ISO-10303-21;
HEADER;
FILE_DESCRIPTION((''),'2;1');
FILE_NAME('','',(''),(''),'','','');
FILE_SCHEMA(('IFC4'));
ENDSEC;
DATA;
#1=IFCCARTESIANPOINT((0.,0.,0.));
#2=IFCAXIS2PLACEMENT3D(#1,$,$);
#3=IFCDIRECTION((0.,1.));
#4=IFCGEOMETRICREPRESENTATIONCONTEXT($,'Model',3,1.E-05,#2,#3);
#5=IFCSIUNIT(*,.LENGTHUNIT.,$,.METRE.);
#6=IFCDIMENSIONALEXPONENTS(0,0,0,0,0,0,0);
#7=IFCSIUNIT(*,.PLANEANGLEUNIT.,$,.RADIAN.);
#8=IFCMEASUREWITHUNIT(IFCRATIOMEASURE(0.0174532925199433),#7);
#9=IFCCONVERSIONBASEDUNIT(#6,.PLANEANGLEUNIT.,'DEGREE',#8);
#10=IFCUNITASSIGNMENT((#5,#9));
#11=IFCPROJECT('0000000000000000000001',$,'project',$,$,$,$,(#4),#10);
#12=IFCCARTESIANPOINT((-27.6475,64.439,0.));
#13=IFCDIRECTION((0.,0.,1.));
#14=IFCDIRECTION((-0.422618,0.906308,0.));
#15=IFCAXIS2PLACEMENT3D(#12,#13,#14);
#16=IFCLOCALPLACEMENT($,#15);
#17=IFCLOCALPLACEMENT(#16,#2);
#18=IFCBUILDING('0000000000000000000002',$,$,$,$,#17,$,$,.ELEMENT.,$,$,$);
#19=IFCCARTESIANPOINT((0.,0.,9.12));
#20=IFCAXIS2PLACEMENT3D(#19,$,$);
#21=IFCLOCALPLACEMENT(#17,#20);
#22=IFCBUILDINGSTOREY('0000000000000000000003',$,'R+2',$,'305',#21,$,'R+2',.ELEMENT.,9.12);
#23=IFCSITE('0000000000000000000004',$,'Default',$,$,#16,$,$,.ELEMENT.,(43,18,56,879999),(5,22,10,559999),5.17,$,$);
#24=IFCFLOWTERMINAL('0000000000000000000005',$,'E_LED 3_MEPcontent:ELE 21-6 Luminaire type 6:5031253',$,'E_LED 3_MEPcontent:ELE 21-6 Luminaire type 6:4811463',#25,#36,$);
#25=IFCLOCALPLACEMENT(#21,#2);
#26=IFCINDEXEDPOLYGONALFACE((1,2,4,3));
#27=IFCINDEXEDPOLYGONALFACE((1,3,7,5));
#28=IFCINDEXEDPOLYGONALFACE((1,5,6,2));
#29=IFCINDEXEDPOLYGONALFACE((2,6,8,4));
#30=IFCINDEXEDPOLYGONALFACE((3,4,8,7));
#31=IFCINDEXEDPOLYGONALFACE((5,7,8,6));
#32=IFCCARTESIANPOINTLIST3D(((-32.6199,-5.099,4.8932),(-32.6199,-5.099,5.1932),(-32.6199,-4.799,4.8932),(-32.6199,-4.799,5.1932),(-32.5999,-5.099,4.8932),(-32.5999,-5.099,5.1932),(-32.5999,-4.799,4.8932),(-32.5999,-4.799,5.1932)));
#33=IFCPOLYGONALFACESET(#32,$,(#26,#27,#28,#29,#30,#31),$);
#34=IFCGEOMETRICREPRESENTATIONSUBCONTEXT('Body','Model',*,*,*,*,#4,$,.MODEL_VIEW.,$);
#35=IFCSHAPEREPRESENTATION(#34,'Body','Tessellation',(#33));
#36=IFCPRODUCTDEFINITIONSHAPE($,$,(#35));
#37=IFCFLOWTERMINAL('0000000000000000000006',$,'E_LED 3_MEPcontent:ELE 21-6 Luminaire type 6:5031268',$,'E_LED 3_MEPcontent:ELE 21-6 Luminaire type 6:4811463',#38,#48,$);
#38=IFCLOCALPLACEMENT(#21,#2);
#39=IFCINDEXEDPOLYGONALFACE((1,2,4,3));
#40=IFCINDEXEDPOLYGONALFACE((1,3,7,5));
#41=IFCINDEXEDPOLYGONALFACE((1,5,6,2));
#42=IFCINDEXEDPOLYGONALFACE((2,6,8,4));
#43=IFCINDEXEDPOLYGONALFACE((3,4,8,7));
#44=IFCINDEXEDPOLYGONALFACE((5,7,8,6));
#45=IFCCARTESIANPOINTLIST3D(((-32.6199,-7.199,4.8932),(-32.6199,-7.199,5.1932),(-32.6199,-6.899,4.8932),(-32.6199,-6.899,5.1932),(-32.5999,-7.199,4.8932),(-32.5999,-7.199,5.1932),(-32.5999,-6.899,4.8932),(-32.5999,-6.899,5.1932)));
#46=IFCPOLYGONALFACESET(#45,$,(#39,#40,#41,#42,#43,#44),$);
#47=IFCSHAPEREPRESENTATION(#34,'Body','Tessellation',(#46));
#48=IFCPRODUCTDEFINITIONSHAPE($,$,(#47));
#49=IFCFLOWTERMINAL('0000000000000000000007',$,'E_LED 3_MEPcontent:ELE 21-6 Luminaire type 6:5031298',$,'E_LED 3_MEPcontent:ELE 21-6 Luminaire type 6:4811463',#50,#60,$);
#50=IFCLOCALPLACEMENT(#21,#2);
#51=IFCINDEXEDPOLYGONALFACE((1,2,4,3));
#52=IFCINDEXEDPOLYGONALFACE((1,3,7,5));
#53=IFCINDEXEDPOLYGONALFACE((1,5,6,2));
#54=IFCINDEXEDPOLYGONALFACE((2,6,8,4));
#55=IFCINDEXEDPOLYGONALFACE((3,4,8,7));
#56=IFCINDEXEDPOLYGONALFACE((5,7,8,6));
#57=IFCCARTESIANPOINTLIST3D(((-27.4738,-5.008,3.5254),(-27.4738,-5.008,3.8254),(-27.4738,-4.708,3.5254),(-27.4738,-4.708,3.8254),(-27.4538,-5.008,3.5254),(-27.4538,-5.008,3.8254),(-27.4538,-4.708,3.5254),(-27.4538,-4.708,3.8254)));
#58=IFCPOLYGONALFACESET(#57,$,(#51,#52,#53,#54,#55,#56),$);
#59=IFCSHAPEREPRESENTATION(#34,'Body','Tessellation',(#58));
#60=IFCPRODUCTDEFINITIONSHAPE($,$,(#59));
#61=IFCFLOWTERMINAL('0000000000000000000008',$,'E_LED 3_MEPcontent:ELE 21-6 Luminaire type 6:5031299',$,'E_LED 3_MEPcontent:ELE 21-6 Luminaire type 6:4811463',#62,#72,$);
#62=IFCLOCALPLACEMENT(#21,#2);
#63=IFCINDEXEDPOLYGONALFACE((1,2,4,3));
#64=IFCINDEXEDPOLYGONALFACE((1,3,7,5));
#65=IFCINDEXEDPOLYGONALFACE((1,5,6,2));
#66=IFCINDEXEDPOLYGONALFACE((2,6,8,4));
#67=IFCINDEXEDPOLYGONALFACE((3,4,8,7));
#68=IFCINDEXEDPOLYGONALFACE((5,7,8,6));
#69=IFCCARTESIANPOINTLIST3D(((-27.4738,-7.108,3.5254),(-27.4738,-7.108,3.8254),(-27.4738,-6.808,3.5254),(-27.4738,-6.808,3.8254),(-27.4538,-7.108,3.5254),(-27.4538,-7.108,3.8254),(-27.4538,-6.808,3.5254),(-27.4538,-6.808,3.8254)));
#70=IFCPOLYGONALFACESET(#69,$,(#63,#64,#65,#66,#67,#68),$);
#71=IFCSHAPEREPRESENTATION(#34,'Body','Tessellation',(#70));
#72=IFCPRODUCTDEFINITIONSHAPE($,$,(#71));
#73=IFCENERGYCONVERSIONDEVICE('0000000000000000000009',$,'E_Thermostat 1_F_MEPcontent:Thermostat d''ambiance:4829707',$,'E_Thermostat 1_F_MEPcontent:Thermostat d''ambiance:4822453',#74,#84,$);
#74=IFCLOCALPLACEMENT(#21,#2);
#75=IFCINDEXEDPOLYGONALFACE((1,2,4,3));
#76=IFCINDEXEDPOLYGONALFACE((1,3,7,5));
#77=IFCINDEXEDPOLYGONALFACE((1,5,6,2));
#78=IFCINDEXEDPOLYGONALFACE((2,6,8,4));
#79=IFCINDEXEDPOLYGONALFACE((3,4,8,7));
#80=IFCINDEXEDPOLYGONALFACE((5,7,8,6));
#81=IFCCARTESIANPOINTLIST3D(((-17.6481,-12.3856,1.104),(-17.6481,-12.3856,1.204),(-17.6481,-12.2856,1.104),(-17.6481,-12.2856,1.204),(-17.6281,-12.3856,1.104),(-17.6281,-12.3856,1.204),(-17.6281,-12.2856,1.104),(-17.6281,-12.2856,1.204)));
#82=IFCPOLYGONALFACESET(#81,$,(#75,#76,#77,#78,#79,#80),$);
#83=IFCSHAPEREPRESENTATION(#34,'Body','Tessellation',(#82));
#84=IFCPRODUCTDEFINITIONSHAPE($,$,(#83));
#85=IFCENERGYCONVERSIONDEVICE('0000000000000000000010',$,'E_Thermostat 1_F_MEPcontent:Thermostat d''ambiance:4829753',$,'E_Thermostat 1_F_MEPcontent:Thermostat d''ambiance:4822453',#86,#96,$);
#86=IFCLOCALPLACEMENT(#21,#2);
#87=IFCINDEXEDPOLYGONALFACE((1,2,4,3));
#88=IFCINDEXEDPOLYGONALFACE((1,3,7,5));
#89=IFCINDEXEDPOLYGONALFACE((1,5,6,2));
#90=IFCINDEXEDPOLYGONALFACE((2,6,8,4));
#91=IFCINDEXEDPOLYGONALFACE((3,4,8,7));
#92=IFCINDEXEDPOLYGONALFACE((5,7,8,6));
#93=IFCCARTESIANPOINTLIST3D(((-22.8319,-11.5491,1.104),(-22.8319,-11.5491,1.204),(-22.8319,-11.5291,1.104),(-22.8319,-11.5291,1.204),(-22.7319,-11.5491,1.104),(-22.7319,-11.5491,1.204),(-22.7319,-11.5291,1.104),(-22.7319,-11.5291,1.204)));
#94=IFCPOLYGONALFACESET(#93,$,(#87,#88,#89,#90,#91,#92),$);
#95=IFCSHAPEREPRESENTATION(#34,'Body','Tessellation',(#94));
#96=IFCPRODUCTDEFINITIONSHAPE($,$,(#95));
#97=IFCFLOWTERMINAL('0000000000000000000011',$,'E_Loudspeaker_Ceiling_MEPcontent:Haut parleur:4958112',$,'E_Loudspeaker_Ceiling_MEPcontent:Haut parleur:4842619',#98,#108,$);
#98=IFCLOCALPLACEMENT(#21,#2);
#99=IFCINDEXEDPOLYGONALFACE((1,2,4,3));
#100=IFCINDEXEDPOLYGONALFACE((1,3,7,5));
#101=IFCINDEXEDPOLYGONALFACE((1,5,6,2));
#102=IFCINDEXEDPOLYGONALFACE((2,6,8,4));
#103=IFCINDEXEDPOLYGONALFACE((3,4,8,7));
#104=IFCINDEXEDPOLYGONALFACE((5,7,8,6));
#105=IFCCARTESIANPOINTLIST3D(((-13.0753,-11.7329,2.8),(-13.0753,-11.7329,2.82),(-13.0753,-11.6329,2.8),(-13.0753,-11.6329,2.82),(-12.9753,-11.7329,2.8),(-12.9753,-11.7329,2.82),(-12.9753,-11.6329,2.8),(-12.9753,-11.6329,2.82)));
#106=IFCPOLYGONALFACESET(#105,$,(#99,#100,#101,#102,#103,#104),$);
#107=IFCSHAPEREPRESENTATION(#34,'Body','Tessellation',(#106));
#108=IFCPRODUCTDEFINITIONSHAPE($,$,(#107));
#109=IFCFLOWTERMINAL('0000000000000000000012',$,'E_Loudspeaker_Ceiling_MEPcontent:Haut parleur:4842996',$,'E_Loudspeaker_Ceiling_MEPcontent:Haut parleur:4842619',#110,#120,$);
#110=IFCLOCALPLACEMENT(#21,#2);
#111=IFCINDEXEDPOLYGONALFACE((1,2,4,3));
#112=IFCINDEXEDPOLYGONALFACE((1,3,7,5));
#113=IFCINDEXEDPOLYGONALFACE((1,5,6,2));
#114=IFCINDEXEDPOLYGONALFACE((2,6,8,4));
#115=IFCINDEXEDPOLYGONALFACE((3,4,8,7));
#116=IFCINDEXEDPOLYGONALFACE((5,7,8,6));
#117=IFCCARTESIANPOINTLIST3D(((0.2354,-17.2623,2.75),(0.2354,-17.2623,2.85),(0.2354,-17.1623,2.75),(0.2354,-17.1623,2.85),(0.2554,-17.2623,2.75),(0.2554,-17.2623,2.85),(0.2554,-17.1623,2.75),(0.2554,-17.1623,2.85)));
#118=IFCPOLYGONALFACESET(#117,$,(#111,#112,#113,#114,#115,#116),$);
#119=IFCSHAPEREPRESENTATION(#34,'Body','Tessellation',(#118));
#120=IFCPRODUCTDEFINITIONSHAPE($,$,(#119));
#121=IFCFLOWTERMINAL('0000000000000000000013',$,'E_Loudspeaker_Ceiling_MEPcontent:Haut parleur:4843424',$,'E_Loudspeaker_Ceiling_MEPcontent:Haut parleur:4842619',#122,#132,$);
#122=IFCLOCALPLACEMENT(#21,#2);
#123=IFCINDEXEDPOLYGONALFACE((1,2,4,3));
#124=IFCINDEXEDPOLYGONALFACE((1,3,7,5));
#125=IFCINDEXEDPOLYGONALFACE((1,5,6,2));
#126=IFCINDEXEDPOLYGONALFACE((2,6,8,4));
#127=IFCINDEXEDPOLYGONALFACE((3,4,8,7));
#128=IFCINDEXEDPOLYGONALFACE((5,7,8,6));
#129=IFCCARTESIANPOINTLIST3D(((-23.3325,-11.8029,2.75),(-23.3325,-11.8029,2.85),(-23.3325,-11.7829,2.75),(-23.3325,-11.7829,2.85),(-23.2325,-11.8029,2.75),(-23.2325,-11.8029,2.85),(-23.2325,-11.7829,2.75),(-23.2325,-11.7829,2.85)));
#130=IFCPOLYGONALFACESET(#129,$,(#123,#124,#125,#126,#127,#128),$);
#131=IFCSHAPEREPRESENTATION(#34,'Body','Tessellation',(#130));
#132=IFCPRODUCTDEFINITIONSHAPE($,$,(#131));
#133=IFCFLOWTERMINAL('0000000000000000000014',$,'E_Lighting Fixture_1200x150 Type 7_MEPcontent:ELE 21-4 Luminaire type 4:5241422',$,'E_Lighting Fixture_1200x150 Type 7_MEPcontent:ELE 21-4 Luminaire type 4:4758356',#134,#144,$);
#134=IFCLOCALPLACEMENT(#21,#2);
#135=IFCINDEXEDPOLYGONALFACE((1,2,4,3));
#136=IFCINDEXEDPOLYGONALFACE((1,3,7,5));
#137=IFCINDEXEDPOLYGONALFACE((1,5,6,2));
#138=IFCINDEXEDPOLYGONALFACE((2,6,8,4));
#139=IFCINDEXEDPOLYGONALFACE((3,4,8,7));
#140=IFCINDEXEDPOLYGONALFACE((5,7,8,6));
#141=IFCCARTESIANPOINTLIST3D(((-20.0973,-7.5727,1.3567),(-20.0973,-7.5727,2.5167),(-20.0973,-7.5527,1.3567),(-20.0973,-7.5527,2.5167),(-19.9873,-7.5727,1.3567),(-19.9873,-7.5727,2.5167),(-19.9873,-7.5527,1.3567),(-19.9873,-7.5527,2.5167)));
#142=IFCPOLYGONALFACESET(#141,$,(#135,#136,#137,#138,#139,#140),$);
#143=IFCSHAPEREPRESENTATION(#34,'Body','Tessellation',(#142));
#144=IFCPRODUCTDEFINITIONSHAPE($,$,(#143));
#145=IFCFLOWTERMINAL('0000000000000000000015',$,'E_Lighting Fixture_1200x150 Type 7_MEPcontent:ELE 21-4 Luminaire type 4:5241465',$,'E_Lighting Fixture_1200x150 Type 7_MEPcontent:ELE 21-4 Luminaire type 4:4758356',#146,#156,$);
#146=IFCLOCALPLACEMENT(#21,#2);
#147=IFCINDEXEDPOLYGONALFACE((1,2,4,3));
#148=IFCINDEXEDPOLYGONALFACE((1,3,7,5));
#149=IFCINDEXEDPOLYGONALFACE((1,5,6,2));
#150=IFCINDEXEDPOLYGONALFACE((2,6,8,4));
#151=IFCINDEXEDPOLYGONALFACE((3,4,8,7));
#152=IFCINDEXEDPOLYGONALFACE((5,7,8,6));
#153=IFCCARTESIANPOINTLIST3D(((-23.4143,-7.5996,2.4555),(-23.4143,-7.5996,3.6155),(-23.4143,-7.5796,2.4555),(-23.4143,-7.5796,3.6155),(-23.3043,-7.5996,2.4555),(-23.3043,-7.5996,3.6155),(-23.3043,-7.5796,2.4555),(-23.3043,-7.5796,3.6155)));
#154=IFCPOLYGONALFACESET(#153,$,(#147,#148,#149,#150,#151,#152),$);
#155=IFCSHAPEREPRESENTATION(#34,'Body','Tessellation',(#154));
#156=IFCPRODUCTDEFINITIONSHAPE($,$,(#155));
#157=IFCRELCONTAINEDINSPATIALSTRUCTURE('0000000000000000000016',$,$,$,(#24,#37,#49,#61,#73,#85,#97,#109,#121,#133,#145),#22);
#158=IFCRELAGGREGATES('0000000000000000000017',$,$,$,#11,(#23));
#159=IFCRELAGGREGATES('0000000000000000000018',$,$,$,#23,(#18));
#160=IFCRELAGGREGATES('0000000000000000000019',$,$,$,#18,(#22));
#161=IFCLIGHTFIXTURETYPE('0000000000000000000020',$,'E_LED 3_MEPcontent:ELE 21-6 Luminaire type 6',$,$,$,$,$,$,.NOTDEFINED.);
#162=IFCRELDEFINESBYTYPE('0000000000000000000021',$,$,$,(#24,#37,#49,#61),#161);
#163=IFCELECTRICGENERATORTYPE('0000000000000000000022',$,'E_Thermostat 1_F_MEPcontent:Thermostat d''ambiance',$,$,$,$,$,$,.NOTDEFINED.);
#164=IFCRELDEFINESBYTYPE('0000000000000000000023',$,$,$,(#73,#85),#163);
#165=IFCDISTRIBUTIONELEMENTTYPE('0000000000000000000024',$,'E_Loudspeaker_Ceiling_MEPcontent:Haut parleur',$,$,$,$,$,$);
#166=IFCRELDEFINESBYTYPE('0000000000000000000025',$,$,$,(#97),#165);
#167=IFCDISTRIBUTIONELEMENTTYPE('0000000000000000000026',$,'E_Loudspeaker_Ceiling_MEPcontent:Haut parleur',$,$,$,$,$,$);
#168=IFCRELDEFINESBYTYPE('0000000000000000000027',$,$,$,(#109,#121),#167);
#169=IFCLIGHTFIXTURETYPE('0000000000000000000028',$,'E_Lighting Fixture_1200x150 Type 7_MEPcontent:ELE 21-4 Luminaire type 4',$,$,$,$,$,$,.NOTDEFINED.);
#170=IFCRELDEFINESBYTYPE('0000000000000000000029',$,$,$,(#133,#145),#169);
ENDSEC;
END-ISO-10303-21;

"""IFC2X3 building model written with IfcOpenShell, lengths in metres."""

from ifc_helpers import new_model, entity, si_unit, converted_unit, direction, frame, frame_2d, origin, origin_2d_with_axis, place, context, subcontext, project, spatial, rectangle, extrude, source, transform, mapped, type_object, type_shapes, element, save


model = new_model("IFC2X3")

# Units and contexts
model_context = context("Model", 3, precision=1e-05, world=origin(), true_north=direction((0.0, 1.0)))
body_context = subcontext(model_context, "Body", "Model", "MODEL_VIEW")
ifc_project = project(units=[si_unit("LENGTHUNIT", "METRE"), converted_unit("PLANEANGLEUNIT", "DEGREE", entity("IfcRatioMeasure", 0.0174532925199433), si_unit("PLANEANGLEUNIT", "RADIAN"), dimensions=[0, 0, 0, 0, 0, 0, 0])], contexts=[model_context])

# Site, building, storey
site_placement = place(None, frame((-27.6475, 64.439, 0.0), z_axis=(0.0, 0.0, 1.0), x_axis=(-0.422618, 0.906308, 0.0)))
site = spatial("IfcSite", under=ifc_project, at=site_placement, Name="Default", CompositionType="ELEMENT", RefLatitude=(43, 18, 56, 879999), RefLongitude=(5, 22, 10, 559999), RefElevation=5.17)
building_placement = place(site_placement, origin())
building = spatial("IfcBuilding", under=site, at=building_placement, CompositionType="ELEMENT")
storey_placement = place(building_placement, frame((0.0, 0.0, 9.12)))
storey = spatial("IfcBuildingStorey", under=building, at=storey_placement, Name="R+2", ObjectType="305", LongName="R+2", CompositionType="ELEMENT", Elevation=9.12)

# Flow terminals
light_fixture_type_1 = type_object("IfcLightFixtureType", Name="E_LED 3_MEPcontent:ELE 21-6 Luminaire type 6", PredefinedType="NOTDEFINED")
shared_shape_1 = source(origin(), body_context, "Body", "SweptSolid", [
    extrude(rectangle(XDim=0.02, YDim=0.3, at=origin_2d_with_axis()), frame((0.0, 0.01, -0.15), z_axis=(0.0, 0.0, 1.0), x_axis=(0.0, -1.0, 0.0)), (0.0, 0.0, 1.0), 0.3),
])
type_shapes(light_fixture_type_1, [shared_shape_1])
for number, where, z_axis, x_axis, name in (
    (1, (-32.6199, -4.949, 5.0432), (0.0, 0.0, 1.0), (0.0, -1.0, 0.0), "E_LED 3_MEPcontent:ELE 21-6 Luminaire type 6:5031253"),
    (2, (-32.6199, -7.049, 5.0432), (0.0, 0.0, 1.0), (0.0, -1.0, 0.0), "E_LED 3_MEPcontent:ELE 21-6 Luminaire type 6:5031268"),
    (3, (-27.4738, -4.858, 3.6754), (0.0, 0.0, 1.0), (0.0, -1.0, 0.0), "E_LED 3_MEPcontent:ELE 21-6 Luminaire type 6:5031298"),
    (4, (-27.4738, -6.958, 3.6754), (0.0, 0.0, 1.0), (0.0, -1.0, 0.0), "E_LED 3_MEPcontent:ELE 21-6 Luminaire type 6:5031299"),
):
    element("IfcFlowTerminal", number, at=place(storey_placement, frame(where, z_axis=z_axis, x_axis=x_axis)), inside=storey, type_object=light_fixture_type_1, Name=name, ObjectType="E_LED 3_MEPcontent:ELE 21-6 Luminaire type 6:4811463", context=body_context, shape_type="MappedRepresentation", body=[
        mapped(shared_shape_1, transform((0.0, 0.0, 0.0), scale=1.0)),
    ])

# Energy conversion devices
electric_generator_type = type_object("IfcElectricGeneratorType", Name="E_Thermostat 1_F_MEPcontent:Thermostat d'ambiance", PredefinedType="NOTDEFINED")
shared_shape_2 = source(origin(), body_context, "Body", "SweptSolid", [
    extrude(rectangle(XDim=0.1, YDim=0.1, at=origin_2d_with_axis()), frame((0.0, 0.0, 0.0), z_axis=(0.0, 0.0, 1.0), x_axis=(0.0, 1.0, 0.0)), (0.0, 0.0, 1.0), 0.02),
])
type_shapes(electric_generator_type, [shared_shape_2])
for number, where, z_axis, x_axis, name in (
    (5, (-17.6481, -12.3356, 1.154), (1.0, 0.0, 0.0), (0.0, 1.0, 0.0), "E_Thermostat 1_F_MEPcontent:Thermostat d'ambiance:4829707"),
    (6, (-22.7819, -11.5291, 1.154), (0.0, -1.0, 0.0), (-1.0, 0.0, 0.0), "E_Thermostat 1_F_MEPcontent:Thermostat d'ambiance:4829753"),
):
    element("IfcEnergyConversionDevice", number, at=place(storey_placement, frame(where, z_axis=z_axis, x_axis=x_axis)), inside=storey, type_object=electric_generator_type, Name=name, ObjectType="E_Thermostat 1_F_MEPcontent:Thermostat d'ambiance:4822453", context=body_context, shape_type="MappedRepresentation", body=[
        mapped(shared_shape_2, transform((0.0, 0.0, 0.0), scale=1.0)),
    ])

# Flow terminals
distribution_element_type_1 = type_object("IfcDistributionElementType", Name="E_Loudspeaker_Ceiling_MEPcontent:Haut parleur")
shared_shape_3 = source(origin(), body_context, "Body", "SweptSolid", [
    extrude(rectangle(XDim=0.1, YDim=0.1, at=origin_2d_with_axis()), frame((0.0, 0.0, 0.0), z_axis=(0.0, 0.0, 1.0), x_axis=(0.0, -1.0, 0.0)), (0.0, 0.0, 1.0), 0.02),
])
type_shapes(distribution_element_type_1, [shared_shape_3])
flow_terminal_1_placement = place(storey_placement, frame((-13.0253, -11.6829, 2.8), z_axis=(0.0, 0.0, 1.0), x_axis=(0.0, 1.0, 0.0)))
element("IfcFlowTerminal", 7, at=flow_terminal_1_placement, inside=storey, type_object=distribution_element_type_1, Name="E_Loudspeaker_Ceiling_MEPcontent:Haut parleur:4958112", ObjectType="E_Loudspeaker_Ceiling_MEPcontent:Haut parleur:4842619", context=body_context, shape_type="MappedRepresentation", body=[
    mapped(shared_shape_3, transform((0.0, 0.0, 0.0), scale=1.0)),
])
distribution_element_type_2 = type_object("IfcDistributionElementType", Name="E_Loudspeaker_Ceiling_MEPcontent:Haut parleur")
shared_shape_4 = source(origin(), body_context, "Body", "SweptSolid", [
    extrude(rectangle(XDim=0.02, YDim=0.1, at=frame_2d((0.0, 0.0), x_axis=(1.0, 0.0))), frame((0.0, 0.01, -0.05), z_axis=(0.0, 0.0, 1.0), x_axis=(0.0, -1.0, 0.0)), (0.0, 0.0, 1.0), 0.1),
])
type_shapes(distribution_element_type_2, [shared_shape_4])
for number, where, z_axis, x_axis, name in (
    (8, (0.2554, -17.2123, 2.8), (0.0, 0.0, 1.0), (0.0, 1.0, 0.0), "E_Loudspeaker_Ceiling_MEPcontent:Haut parleur:4842996"),
    (9, (-23.2825, -11.7829, 2.8), (0.0, 0.0, 1.0), (-1.0, 0.0, 0.0), "E_Loudspeaker_Ceiling_MEPcontent:Haut parleur:4843424"),
):
    element("IfcFlowTerminal", number, at=place(storey_placement, frame(where, z_axis=z_axis, x_axis=x_axis)), inside=storey, type_object=distribution_element_type_2, Name=name, ObjectType="E_Loudspeaker_Ceiling_MEPcontent:Haut parleur:4842619", context=body_context, shape_type="MappedRepresentation", body=[
        mapped(shared_shape_4, transform((0.0, 0.0, 0.0), scale=1.0)),
    ])
light_fixture_type_2 = type_object("IfcLightFixtureType", Name="E_Lighting Fixture_1200x150 Type 7_MEPcontent:ELE 21-4 Luminaire type 4", PredefinedType="NOTDEFINED")
shared_shape_5 = source(origin(), body_context, "Body", "SweptSolid", [
    extrude(rectangle(XDim=0.02, YDim=0.11, at=frame_2d((0.0, 0.0), x_axis=(1.0, 0.0))), frame((0.0, 0.01, -0.58), z_axis=(0.0, 0.0, 1.0), x_axis=(0.0, -1.0, 0.0)), (0.0, 0.0, 1.0), 1.16),
])
type_shapes(light_fixture_type_2, [shared_shape_5])
for number, where, name in (
    (10, (-20.0423, -7.5727, 1.9367), "E_Lighting Fixture_1200x150 Type 7_MEPcontent:ELE 21-4 Luminaire type 4:5241422"),
    (11, (-23.3593, -7.5996, 3.0355), "E_Lighting Fixture_1200x150 Type 7_MEPcontent:ELE 21-4 Luminaire type 4:5241465"),
):
    element("IfcFlowTerminal", number, at=place(storey_placement, frame(where)), inside=storey, type_object=light_fixture_type_2, Name=name, ObjectType="E_Lighting Fixture_1200x150 Type 7_MEPcontent:ELE 21-4 Luminaire type 4:4758356", context=body_context, shape_type="MappedRepresentation", body=[
        mapped(shared_shape_5, transform((0.0, 0.0, 0.0), scale=1.0)),
    ])

save(model, "model.ifc")
